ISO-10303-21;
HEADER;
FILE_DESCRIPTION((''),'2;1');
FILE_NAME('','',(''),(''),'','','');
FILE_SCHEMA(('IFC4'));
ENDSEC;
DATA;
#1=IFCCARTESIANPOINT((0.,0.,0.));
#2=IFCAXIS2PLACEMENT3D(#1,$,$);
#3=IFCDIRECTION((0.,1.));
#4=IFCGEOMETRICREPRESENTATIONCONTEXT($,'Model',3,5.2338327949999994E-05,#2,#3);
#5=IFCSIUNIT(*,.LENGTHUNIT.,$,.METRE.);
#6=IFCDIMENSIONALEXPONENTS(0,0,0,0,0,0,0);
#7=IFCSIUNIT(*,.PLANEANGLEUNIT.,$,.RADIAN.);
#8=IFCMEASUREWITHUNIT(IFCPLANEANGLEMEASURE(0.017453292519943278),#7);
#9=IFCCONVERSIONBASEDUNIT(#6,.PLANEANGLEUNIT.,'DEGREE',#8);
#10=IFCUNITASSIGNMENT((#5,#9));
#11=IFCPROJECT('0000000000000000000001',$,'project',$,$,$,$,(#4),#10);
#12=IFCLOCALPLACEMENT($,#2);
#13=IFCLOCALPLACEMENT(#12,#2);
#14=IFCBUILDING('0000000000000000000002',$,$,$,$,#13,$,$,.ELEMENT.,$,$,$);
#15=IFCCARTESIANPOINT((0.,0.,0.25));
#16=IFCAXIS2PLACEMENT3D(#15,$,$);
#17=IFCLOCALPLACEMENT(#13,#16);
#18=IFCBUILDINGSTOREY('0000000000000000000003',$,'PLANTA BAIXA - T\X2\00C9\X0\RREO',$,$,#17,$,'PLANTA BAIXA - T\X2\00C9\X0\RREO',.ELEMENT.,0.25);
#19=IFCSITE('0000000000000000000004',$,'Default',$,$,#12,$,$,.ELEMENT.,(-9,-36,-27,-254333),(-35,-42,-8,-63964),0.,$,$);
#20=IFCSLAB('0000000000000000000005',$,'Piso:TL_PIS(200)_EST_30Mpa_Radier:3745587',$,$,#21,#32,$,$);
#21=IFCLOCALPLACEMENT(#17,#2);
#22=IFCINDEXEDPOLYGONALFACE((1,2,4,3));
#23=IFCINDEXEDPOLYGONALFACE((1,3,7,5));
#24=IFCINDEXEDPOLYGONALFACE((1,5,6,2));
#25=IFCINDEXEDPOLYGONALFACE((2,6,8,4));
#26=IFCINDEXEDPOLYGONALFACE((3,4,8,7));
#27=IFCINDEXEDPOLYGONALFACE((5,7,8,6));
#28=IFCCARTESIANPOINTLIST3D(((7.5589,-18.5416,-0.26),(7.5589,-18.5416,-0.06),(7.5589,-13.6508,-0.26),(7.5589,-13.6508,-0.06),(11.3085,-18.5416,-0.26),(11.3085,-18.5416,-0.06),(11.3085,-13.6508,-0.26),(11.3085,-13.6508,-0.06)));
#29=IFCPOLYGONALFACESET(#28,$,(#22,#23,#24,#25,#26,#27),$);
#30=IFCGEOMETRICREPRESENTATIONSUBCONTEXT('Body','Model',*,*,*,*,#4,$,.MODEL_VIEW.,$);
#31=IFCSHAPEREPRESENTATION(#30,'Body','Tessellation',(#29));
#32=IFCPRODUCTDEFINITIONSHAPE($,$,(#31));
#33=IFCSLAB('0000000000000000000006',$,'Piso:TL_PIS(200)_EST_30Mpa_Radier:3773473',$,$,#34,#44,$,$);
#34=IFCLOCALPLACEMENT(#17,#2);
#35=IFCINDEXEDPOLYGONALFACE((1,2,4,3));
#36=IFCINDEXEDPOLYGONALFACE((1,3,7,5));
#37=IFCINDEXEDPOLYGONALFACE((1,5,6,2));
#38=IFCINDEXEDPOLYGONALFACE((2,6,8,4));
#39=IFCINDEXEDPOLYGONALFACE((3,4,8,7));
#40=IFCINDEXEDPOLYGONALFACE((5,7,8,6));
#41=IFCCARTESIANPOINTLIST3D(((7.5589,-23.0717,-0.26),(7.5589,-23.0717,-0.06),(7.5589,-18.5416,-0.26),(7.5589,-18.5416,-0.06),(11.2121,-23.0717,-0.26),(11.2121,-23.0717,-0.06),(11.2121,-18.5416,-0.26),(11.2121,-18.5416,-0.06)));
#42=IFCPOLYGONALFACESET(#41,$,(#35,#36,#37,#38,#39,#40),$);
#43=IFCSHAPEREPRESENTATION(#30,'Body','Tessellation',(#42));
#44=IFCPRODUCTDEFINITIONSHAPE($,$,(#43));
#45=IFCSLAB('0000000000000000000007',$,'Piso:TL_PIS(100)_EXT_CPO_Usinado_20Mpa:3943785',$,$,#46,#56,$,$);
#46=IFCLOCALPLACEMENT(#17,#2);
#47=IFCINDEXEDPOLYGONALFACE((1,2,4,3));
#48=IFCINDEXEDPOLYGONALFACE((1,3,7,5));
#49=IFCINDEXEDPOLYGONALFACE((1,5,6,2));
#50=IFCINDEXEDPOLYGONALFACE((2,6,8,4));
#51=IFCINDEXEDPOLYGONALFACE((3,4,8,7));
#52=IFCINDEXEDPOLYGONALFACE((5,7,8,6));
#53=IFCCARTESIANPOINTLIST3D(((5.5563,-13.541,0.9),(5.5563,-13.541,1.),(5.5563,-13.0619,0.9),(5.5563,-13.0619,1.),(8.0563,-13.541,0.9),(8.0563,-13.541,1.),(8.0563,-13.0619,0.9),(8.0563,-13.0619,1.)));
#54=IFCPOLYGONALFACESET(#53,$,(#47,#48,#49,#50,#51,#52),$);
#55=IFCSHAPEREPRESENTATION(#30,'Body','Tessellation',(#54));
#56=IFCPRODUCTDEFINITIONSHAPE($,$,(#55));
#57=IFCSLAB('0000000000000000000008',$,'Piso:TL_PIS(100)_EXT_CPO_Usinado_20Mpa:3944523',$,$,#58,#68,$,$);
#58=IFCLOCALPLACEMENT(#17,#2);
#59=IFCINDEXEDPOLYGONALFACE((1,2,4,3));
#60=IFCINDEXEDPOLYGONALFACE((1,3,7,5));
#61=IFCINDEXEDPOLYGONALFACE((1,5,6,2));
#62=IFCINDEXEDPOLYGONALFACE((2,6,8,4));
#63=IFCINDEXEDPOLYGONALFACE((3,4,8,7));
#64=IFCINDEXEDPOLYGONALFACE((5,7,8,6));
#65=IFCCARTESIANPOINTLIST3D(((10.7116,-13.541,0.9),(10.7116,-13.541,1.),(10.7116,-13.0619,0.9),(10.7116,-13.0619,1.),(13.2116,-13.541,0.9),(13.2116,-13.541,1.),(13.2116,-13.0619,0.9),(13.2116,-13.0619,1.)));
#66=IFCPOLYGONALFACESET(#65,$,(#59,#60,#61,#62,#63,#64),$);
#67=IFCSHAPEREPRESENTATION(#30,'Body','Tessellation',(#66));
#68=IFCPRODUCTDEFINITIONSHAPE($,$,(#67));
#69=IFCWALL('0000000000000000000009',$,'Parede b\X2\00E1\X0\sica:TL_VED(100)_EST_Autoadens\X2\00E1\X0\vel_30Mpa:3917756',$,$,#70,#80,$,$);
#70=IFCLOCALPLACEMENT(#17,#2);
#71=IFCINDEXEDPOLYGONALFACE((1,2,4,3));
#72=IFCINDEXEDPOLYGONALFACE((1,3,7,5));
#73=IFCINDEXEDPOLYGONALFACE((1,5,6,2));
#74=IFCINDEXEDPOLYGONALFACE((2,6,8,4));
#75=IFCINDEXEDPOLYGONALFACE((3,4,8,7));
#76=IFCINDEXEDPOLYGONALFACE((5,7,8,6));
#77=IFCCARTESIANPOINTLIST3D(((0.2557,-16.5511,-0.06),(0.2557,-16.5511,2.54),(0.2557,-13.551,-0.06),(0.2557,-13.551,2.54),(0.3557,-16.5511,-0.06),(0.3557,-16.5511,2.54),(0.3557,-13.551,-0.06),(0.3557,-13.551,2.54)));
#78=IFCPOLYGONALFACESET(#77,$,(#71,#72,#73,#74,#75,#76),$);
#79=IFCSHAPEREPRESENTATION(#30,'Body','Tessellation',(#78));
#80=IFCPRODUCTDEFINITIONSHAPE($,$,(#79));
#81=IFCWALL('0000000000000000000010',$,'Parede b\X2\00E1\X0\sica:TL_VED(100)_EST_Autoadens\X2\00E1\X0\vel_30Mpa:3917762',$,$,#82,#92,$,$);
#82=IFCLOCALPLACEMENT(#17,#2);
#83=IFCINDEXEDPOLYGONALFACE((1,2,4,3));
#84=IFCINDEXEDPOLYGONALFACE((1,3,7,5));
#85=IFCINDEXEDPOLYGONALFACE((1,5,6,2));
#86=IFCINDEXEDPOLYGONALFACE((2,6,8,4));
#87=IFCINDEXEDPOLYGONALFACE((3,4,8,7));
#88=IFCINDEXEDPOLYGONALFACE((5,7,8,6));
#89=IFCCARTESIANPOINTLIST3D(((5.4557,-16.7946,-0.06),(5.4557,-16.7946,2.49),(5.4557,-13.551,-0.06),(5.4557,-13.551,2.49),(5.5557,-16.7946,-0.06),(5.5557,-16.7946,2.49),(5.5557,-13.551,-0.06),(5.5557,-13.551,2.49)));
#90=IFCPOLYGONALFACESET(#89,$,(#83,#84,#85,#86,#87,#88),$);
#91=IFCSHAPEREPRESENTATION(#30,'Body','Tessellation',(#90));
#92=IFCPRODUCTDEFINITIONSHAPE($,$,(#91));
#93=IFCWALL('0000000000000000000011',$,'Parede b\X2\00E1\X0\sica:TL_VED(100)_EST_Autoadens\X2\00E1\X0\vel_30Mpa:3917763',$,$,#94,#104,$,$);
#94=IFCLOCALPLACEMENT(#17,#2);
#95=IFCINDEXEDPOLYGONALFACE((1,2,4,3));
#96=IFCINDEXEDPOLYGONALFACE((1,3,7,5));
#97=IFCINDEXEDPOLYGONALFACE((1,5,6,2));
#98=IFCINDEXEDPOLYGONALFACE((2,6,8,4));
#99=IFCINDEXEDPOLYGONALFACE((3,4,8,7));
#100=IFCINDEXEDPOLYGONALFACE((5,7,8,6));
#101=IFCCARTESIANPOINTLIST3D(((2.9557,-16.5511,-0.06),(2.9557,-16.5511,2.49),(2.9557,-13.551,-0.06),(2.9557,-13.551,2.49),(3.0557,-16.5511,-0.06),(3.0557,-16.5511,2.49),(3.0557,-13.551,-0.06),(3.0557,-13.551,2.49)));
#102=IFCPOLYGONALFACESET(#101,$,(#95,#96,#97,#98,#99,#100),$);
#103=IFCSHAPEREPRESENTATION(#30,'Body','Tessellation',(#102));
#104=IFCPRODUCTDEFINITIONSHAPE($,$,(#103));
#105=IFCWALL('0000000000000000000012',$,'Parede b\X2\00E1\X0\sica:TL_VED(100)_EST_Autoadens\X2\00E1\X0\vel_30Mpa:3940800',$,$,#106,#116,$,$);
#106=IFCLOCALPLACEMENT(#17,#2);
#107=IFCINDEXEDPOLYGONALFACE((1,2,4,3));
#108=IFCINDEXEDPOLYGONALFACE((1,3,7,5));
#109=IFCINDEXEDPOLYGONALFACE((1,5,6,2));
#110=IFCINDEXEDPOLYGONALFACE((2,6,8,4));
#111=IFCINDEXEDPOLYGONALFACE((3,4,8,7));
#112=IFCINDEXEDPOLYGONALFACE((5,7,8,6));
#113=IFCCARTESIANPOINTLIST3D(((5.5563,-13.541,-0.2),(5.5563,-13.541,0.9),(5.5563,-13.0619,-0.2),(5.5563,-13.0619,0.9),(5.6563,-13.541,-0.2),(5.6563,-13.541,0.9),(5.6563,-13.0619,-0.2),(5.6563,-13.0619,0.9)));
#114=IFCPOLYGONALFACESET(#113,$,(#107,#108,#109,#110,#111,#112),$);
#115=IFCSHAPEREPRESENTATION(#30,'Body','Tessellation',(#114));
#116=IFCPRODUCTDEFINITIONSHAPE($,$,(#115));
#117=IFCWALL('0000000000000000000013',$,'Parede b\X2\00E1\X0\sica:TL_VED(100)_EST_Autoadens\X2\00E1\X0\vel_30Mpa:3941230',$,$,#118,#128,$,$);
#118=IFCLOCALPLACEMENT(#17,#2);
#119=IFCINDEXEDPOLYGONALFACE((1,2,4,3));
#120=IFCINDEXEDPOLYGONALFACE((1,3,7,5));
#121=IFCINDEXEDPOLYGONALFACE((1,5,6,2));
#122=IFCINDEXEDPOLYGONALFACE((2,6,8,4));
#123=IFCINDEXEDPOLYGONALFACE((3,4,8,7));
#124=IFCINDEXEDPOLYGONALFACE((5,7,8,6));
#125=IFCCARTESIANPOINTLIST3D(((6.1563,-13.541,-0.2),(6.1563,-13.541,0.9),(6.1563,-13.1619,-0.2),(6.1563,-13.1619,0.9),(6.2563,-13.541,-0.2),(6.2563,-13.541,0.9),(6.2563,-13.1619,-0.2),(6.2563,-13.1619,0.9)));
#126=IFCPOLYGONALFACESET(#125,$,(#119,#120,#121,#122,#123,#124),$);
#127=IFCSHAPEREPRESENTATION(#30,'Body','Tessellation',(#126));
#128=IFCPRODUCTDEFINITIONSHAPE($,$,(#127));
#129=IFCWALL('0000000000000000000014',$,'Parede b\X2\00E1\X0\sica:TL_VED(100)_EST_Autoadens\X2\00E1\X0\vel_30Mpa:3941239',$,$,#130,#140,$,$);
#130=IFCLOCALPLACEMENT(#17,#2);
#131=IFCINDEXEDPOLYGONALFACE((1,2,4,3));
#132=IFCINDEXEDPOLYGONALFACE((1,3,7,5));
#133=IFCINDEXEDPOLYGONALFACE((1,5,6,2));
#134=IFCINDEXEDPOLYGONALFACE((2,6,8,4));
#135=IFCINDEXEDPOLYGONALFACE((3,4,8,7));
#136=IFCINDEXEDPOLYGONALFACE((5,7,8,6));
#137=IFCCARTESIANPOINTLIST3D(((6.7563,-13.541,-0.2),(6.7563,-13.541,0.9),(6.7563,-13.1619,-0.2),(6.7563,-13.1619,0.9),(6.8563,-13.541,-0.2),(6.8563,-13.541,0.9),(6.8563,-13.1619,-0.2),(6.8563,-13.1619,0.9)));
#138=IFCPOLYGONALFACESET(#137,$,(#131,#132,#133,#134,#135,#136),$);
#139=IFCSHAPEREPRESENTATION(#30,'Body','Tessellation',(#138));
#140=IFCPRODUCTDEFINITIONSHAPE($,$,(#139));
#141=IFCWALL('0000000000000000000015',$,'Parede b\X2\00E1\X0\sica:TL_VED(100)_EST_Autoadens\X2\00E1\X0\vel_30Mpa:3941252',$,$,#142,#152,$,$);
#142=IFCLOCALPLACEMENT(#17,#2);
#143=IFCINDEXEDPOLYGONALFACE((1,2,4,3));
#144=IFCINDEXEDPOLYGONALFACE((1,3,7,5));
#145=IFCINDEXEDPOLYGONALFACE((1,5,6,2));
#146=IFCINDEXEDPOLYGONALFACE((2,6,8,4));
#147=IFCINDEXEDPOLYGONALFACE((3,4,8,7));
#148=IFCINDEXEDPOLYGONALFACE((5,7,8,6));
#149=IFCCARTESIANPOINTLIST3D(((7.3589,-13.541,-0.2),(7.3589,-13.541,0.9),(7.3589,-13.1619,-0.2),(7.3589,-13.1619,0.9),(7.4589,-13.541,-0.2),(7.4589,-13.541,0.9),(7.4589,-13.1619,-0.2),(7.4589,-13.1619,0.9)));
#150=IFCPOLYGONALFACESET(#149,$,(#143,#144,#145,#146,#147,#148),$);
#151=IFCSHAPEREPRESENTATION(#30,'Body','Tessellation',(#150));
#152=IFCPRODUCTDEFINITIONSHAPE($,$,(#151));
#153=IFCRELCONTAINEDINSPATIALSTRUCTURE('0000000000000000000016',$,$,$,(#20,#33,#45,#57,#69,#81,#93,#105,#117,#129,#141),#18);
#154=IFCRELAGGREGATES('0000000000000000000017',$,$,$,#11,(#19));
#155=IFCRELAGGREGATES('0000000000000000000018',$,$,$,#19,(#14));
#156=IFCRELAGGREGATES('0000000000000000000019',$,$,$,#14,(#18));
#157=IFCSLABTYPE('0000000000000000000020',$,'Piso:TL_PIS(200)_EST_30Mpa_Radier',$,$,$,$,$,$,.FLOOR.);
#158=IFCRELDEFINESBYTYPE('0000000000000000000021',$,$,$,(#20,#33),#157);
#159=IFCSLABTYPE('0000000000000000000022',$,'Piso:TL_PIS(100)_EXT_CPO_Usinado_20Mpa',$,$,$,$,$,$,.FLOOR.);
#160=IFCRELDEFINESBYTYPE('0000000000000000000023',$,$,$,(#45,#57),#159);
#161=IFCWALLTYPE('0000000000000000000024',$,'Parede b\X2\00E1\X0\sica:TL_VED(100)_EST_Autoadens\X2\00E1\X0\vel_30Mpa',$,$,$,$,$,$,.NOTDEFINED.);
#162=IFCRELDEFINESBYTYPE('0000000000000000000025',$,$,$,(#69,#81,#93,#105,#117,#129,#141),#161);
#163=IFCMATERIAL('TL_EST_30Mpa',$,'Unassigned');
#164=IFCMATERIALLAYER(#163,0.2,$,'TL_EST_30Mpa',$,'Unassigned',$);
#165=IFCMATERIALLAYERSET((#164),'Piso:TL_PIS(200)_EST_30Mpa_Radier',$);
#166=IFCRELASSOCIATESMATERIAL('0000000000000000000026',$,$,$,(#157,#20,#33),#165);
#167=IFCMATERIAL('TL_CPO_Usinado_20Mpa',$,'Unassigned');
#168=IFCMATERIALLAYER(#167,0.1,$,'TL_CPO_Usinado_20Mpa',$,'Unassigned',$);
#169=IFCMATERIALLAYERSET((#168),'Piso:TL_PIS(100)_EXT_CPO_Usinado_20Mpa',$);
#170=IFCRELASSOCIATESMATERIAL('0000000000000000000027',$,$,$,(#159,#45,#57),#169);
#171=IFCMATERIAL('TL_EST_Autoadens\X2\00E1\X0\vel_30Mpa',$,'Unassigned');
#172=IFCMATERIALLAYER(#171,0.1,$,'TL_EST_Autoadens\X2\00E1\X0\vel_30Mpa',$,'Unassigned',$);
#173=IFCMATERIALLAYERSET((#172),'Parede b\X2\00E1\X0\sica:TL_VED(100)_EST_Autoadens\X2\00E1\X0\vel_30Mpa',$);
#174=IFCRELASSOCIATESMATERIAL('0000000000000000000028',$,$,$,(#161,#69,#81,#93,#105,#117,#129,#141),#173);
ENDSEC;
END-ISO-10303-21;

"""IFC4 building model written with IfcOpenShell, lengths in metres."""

from ifc_helpers import new_model, entity, si_unit, converted_unit, direction, frame, frame_2d, origin, place, context, subcontext, project, spatial, polyline, rectangle, extrude, clip, bounded_halfspace, material, layer, layer_set, layer_usage, type_object, element, save


model = new_model("IFC4")

# Units and contexts
model_context = context("Model", 3, precision=5.2338327949999994e-05, world=origin(), true_north=direction((0.0, 1.0)))
body_context = subcontext(model_context, "Body", "Model", "MODEL_VIEW")
ifc_project = project(units=[si_unit("LENGTHUNIT", "METRE"), converted_unit("PLANEANGLEUNIT", "DEGREE", entity("IfcPlaneAngleMeasure", 0.017453292519943278), si_unit("PLANEANGLEUNIT", "RADIAN"), dimensions=[0, 0, 0, 0, 0, 0, 0])], contexts=[model_context])

# Site, building, storey
site_placement = place(None, frame((0.0, 0.0, 0.0)))
site = spatial("IfcSite", under=ifc_project, at=site_placement, Name="Default", CompositionType="ELEMENT", RefLatitude=(-9, -36, -27, -254333), RefLongitude=(-35, -42, -8, -63964), RefElevation=0.0)
building_placement = place(site_placement, origin())
building = spatial("IfcBuilding", under=site, at=building_placement, CompositionType="ELEMENT")
storey_placement = place(building_placement, frame((0.0, 0.0, 0.25)))
storey = spatial("IfcBuildingStorey", under=building, at=storey_placement, Name="PLANTA BAIXA - TÉRREO", LongName="PLANTA BAIXA - TÉRREO", CompositionType="ELEMENT", Elevation=0.25)

# Slabs
ifc_material_1 = material(Name="TL_EST_30Mpa", Category="Unassigned")
ifc_layer_1 = layer(ifc_material_1, 0.2, Name="TL_EST_30Mpa", Category="Unassigned")
ifc_layer_set_1 = layer_set([ifc_layer_1], Name="Piso:TL_PIS(200)_EST_30Mpa_Radier")
slab_type_1 = type_object("IfcSlabType", Name="Piso:TL_PIS(200)_EST_30Mpa_Radier", PredefinedType="FLOOR", material=ifc_layer_set_1)
ifc_layer_usage_1 = layer_usage(ifc_layer_set_1, "AXIS3", "POSITIVE", 0.0)
slab_1_placement = place(storey_placement, origin())
element("IfcSlab", 1, at=slab_1_placement, inside=storey, type_object=slab_type_1, material=ifc_layer_usage_1, Name="Piso:TL_PIS(200)_EST_30Mpa_Radier:3745587", context=body_context, shape_type="SweptSolid", body=[
    extrude(rectangle(XDim=4.8908, YDim=3.7495, at=frame_2d((0.0, 0.0), x_axis=(1.0, 0.0))), frame((9.4337, -16.0962, -0.06), z_axis=(0.0, 0.0, -1.0), x_axis=(0.0, 1.0, 0.0)), (0.0, 0.0, 1.0), 0.2),
])
ifc_layer_usage_2 = layer_usage(ifc_layer_set_1, "AXIS3", "POSITIVE", 0.0)
slab_2_placement = place(storey_placement, origin())
element("IfcSlab", 2, at=slab_2_placement, inside=storey, type_object=slab_type_1, material=ifc_layer_usage_2, Name="Piso:TL_PIS(200)_EST_30Mpa_Radier:3773473", context=body_context, shape_type="SweptSolid", body=[
    extrude(rectangle(XDim=4.5301, YDim=3.6532, at=frame_2d((0.0, 0.0), x_axis=(1.0, 0.0))), frame((9.3855, -20.8067, -0.06), z_axis=(0.0, 0.0, -1.0), x_axis=(0.0, 1.0, 0.0)), (0.0, 0.0, 1.0), 0.2),
])
ifc_material_2 = material(Name="TL_CPO_Usinado_20Mpa", Category="Unassigned")
ifc_layer_2 = layer(ifc_material_2, 0.1, Name="TL_CPO_Usinado_20Mpa", Category="Unassigned")
ifc_layer_set_2 = layer_set([ifc_layer_2], Name="Piso:TL_PIS(100)_EXT_CPO_Usinado_20Mpa")
slab_type_2 = type_object("IfcSlabType", Name="Piso:TL_PIS(100)_EXT_CPO_Usinado_20Mpa", PredefinedType="FLOOR", material=ifc_layer_set_2)
ifc_layer_usage_3 = layer_usage(ifc_layer_set_2, "AXIS3", "POSITIVE", 0.0)
slab_3_placement = place(storey_placement, origin())
element("IfcSlab", 3, at=slab_3_placement, inside=storey, type_object=slab_type_2, material=ifc_layer_usage_3, Name="Piso:TL_PIS(100)_EXT_CPO_Usinado_20Mpa:3943785", context=body_context, shape_type="SweptSolid", body=[
    extrude(rectangle(XDim=0.4791, YDim=2.5, at=frame_2d((0.0, 0.0), x_axis=(1.0, 0.0))), frame((6.8063, -13.3014, 1.0), z_axis=(0.0, 0.0, -1.0), x_axis=(0.0, 1.0, 0.0)), (0.0, 0.0, 1.0), 0.1),
])
ifc_layer_usage_4 = layer_usage(ifc_layer_set_2, "AXIS3", "POSITIVE", 0.0)
slab_4_placement = place(storey_placement, origin())
element("IfcSlab", 4, at=slab_4_placement, inside=storey, type_object=slab_type_2, material=ifc_layer_usage_4, Name="Piso:TL_PIS(100)_EXT_CPO_Usinado_20Mpa:3944523", context=body_context, shape_type="SweptSolid", body=[
    extrude(rectangle(XDim=0.4791, YDim=2.5, at=frame_2d((0.0, 0.0), x_axis=(1.0, 0.0))), frame((11.9616, -13.3014, 1.0), z_axis=(0.0, 0.0, -1.0), x_axis=(0.0, 1.0, 0.0)), (0.0, 0.0, 1.0), 0.1),
])

# Walls
ifc_material_3 = material(Name="TL_EST_Autoadensável_30Mpa", Category="Unassigned")
ifc_layer_3 = layer(ifc_material_3, 0.1, Name="TL_EST_Autoadensável_30Mpa", Category="Unassigned")
ifc_layer_set_3 = layer_set([ifc_layer_3], Name="Parede básica:TL_VED(100)_EST_Autoadensável_30Mpa")
ifc_layer_usage_5 = layer_usage(ifc_layer_set_3, "AXIS2", "NEGATIVE", 0.05)
wall_type_1 = type_object("IfcWallType", Name="Parede básica:TL_VED(100)_EST_Autoadensável_30Mpa", PredefinedType="NOTDEFINED", material=ifc_layer_set_3)
wall_1_placement = place(storey_placement, frame((0.3057, -13.551, -0.06), z_axis=(0.0, 0.0, 1.0), x_axis=(0.0, -1.0, 0.0)))
element("IfcWall", 5, at=wall_1_placement, inside=storey, type_object=wall_type_1, material=ifc_layer_usage_5, Name="Parede básica:TL_VED(100)_EST_Autoadensável_30Mpa:3917756", context=body_context, shape_type="SweptSolid", body=[
    extrude(rectangle(XDim=3.0001, YDim=0.1, at=frame_2d((1.5001, 0.0), x_axis=(-1.0, 0.0))), origin(), (0.0, 0.0, 1.0), 2.6),
])
ifc_layer_usage_6 = layer_usage(ifc_layer_set_3, "AXIS2", "NEGATIVE", 0.05)
wall_2_placement = place(storey_placement, frame((5.5057, -13.551, -0.06), z_axis=(0.0, 0.0, 1.0), x_axis=(0.0, -1.0, 0.0)))
element("IfcWall", 6, at=wall_2_placement, inside=storey, type_object=wall_type_1, material=ifc_layer_usage_6, Name="Parede básica:TL_VED(100)_EST_Autoadensável_30Mpa:3917762", context=body_context, shape_type="SweptSolid", body=[
    extrude(rectangle(XDim=3.2437, YDim=0.1, at=frame_2d((1.6218, 0.0), x_axis=(-1.0, 0.0))), origin(), (0.0, 0.0, 1.0), 2.55),
])

# Wall, opening
ifc_layer_usage_7 = layer_usage(ifc_layer_set_3, "AXIS2", "NEGATIVE", 0.05)
wall_3_placement = place(storey_placement, frame((3.0057, -13.551, -0.06), z_axis=(0.0, 0.0, 1.0), x_axis=(0.0, -1.0, 0.0)))
wall_3 = element("IfcWall", 7, at=wall_3_placement, inside=storey, type_object=wall_type_1, material=ifc_layer_usage_7, Name="Parede básica:TL_VED(100)_EST_Autoadensável_30Mpa:3917763", context=body_context, shape_type="SweptSolid", body=[
    extrude(rectangle(XDim=3.0001, YDim=0.1, at=frame_2d((1.5001, 0.0), x_axis=(-1.0, 0.0))), origin(), (0.0, 0.0, 1.0), 2.55),
])
opening_1_placement = place(wall_3_placement, frame((-13.551, -3.0057, 0.06)))
element("IfcOpeningElement", 8, at=opening_1_placement, cuts=wall_3, PredefinedType="OPENING", context=body_context, shape_type="SweptSolid", body=[
    extrude(rectangle(XDim=2.1, YDim=0.1, at=frame_2d((0.0, 0.0), x_axis=(0.0, 1.0))), frame((14.501, 3.0557, 1.05), z_axis=(0.0, 1.0, 0.0), x_axis=(1.0, 0.0, 0.0)), (0.0, 0.0, 1.0), 2.4),
])

# Walls
ifc_layer_usage_8 = layer_usage(ifc_layer_set_3, "AXIS2", "NEGATIVE", 0.05)
wall_4_placement = place(storey_placement, frame((5.6063, -13.0619, -0.2), z_axis=(0.0, 0.0, 1.0), x_axis=(0.0, -1.0, 0.0)))
element("IfcWall", 9, at=wall_4_placement, inside=storey, type_object=wall_type_1, material=ifc_layer_usage_8, Name="Parede básica:TL_VED(100)_EST_Autoadensável_30Mpa:3940800", context=body_context, shape_type="Clipping", body=[
    clip(extrude(rectangle(XDim=0.4791, YDim=0.1, at=frame_2d((0.2395, 0.0), x_axis=(-1.0, 0.0))), origin(), (0.0, 0.0, 1.0), 1.1), bounded_halfspace(frame((0.0, -0.05, 1.1), z_axis=(0.0, 0.0, -1.0), x_axis=(1.0, 0.0, 0.0)), True, frame((0.0, -0.05, 1.1)), polyline([(0.0, 0.0), (0.4791, 0.0), (0.4791, 0.1), (0.1, 0.1), (0.0, 0.1), (0.0, 0.0)]))),
])
ifc_layer_usage_9 = layer_usage(ifc_layer_set_3, "AXIS2", "NEGATIVE", 0.05)
wall_5_placement = place(storey_placement, frame((6.2063, -13.1619, -0.2), z_axis=(0.0, 0.0, 1.0), x_axis=(0.0, -1.0, 0.0)))
element("IfcWall", 10, at=wall_5_placement, inside=storey, type_object=wall_type_1, material=ifc_layer_usage_9, Name="Parede básica:TL_VED(100)_EST_Autoadensável_30Mpa:3941230", context=body_context, shape_type="Clipping", body=[
    clip(extrude(rectangle(XDim=0.3791, YDim=0.1, at=frame_2d((0.1895, 0.0), x_axis=(-1.0, 0.0))), origin(), (0.0, 0.0, 1.0), 1.1), bounded_halfspace(frame((0.0, -0.05, 1.1), z_axis=(0.0, 0.0, -1.0), x_axis=(1.0, 0.0, 0.0)), True, frame((0.0, -0.05, 1.1)), polyline([(0.0, 0.0), (0.3791, 0.0), (0.3791, 0.1), (0.0, 0.1), (0.0, 0.0)]))),
])
ifc_layer_usage_10 = layer_usage(ifc_layer_set_3, "AXIS2", "NEGATIVE", 0.05)
wall_6_placement = place(storey_placement, frame((6.8063, -13.1619, -0.2), z_axis=(0.0, 0.0, 1.0), x_axis=(0.0, -1.0, 0.0)))
element("IfcWall", 11, at=wall_6_placement, inside=storey, type_object=wall_type_1, material=ifc_layer_usage_10, Name="Parede básica:TL_VED(100)_EST_Autoadensável_30Mpa:3941239", context=body_context, shape_type="Clipping", body=[
    clip(extrude(rectangle(XDim=0.3791, YDim=0.1, at=frame_2d((0.1895, 0.0), x_axis=(-1.0, 0.0))), origin(), (0.0, 0.0, 1.0), 1.1), bounded_halfspace(frame((0.0, -0.05, 1.1), z_axis=(0.0, 0.0, -1.0), x_axis=(1.0, 0.0, 0.0)), True, frame((0.0, -0.05, 1.1)), polyline([(0.0, 0.0), (0.3791, 0.0), (0.3791, 0.1), (0.0, 0.1), (0.0, 0.0)]))),
])
ifc_layer_usage_11 = layer_usage(ifc_layer_set_3, "AXIS2", "NEGATIVE", 0.05)
wall_7_placement = place(storey_placement, frame((7.4089, -13.1619, -0.2), z_axis=(0.0, 0.0, 1.0), x_axis=(0.0, -1.0, 0.0)))
element("IfcWall", 12, at=wall_7_placement, inside=storey, type_object=wall_type_1, material=ifc_layer_usage_11, Name="Parede básica:TL_VED(100)_EST_Autoadensável_30Mpa:3941252", context=body_context, shape_type="Clipping", body=[
    clip(extrude(rectangle(XDim=0.3791, YDim=0.1, at=frame_2d((0.1895, 0.0), x_axis=(-1.0, 0.0))), origin(), (0.0, 0.0, 1.0), 1.1), bounded_halfspace(frame((0.0, -0.05, 1.1), z_axis=(0.0, 0.0, -1.0), x_axis=(1.0, 0.0, 0.0)), True, frame((0.0, -0.05, 1.1)), polyline([(0.0, 0.0), (0.3791, 0.0), (0.3791, 0.1), (0.0, 0.1), (0.0, 0.0)]))),
])

save(model, "model.ifc")
